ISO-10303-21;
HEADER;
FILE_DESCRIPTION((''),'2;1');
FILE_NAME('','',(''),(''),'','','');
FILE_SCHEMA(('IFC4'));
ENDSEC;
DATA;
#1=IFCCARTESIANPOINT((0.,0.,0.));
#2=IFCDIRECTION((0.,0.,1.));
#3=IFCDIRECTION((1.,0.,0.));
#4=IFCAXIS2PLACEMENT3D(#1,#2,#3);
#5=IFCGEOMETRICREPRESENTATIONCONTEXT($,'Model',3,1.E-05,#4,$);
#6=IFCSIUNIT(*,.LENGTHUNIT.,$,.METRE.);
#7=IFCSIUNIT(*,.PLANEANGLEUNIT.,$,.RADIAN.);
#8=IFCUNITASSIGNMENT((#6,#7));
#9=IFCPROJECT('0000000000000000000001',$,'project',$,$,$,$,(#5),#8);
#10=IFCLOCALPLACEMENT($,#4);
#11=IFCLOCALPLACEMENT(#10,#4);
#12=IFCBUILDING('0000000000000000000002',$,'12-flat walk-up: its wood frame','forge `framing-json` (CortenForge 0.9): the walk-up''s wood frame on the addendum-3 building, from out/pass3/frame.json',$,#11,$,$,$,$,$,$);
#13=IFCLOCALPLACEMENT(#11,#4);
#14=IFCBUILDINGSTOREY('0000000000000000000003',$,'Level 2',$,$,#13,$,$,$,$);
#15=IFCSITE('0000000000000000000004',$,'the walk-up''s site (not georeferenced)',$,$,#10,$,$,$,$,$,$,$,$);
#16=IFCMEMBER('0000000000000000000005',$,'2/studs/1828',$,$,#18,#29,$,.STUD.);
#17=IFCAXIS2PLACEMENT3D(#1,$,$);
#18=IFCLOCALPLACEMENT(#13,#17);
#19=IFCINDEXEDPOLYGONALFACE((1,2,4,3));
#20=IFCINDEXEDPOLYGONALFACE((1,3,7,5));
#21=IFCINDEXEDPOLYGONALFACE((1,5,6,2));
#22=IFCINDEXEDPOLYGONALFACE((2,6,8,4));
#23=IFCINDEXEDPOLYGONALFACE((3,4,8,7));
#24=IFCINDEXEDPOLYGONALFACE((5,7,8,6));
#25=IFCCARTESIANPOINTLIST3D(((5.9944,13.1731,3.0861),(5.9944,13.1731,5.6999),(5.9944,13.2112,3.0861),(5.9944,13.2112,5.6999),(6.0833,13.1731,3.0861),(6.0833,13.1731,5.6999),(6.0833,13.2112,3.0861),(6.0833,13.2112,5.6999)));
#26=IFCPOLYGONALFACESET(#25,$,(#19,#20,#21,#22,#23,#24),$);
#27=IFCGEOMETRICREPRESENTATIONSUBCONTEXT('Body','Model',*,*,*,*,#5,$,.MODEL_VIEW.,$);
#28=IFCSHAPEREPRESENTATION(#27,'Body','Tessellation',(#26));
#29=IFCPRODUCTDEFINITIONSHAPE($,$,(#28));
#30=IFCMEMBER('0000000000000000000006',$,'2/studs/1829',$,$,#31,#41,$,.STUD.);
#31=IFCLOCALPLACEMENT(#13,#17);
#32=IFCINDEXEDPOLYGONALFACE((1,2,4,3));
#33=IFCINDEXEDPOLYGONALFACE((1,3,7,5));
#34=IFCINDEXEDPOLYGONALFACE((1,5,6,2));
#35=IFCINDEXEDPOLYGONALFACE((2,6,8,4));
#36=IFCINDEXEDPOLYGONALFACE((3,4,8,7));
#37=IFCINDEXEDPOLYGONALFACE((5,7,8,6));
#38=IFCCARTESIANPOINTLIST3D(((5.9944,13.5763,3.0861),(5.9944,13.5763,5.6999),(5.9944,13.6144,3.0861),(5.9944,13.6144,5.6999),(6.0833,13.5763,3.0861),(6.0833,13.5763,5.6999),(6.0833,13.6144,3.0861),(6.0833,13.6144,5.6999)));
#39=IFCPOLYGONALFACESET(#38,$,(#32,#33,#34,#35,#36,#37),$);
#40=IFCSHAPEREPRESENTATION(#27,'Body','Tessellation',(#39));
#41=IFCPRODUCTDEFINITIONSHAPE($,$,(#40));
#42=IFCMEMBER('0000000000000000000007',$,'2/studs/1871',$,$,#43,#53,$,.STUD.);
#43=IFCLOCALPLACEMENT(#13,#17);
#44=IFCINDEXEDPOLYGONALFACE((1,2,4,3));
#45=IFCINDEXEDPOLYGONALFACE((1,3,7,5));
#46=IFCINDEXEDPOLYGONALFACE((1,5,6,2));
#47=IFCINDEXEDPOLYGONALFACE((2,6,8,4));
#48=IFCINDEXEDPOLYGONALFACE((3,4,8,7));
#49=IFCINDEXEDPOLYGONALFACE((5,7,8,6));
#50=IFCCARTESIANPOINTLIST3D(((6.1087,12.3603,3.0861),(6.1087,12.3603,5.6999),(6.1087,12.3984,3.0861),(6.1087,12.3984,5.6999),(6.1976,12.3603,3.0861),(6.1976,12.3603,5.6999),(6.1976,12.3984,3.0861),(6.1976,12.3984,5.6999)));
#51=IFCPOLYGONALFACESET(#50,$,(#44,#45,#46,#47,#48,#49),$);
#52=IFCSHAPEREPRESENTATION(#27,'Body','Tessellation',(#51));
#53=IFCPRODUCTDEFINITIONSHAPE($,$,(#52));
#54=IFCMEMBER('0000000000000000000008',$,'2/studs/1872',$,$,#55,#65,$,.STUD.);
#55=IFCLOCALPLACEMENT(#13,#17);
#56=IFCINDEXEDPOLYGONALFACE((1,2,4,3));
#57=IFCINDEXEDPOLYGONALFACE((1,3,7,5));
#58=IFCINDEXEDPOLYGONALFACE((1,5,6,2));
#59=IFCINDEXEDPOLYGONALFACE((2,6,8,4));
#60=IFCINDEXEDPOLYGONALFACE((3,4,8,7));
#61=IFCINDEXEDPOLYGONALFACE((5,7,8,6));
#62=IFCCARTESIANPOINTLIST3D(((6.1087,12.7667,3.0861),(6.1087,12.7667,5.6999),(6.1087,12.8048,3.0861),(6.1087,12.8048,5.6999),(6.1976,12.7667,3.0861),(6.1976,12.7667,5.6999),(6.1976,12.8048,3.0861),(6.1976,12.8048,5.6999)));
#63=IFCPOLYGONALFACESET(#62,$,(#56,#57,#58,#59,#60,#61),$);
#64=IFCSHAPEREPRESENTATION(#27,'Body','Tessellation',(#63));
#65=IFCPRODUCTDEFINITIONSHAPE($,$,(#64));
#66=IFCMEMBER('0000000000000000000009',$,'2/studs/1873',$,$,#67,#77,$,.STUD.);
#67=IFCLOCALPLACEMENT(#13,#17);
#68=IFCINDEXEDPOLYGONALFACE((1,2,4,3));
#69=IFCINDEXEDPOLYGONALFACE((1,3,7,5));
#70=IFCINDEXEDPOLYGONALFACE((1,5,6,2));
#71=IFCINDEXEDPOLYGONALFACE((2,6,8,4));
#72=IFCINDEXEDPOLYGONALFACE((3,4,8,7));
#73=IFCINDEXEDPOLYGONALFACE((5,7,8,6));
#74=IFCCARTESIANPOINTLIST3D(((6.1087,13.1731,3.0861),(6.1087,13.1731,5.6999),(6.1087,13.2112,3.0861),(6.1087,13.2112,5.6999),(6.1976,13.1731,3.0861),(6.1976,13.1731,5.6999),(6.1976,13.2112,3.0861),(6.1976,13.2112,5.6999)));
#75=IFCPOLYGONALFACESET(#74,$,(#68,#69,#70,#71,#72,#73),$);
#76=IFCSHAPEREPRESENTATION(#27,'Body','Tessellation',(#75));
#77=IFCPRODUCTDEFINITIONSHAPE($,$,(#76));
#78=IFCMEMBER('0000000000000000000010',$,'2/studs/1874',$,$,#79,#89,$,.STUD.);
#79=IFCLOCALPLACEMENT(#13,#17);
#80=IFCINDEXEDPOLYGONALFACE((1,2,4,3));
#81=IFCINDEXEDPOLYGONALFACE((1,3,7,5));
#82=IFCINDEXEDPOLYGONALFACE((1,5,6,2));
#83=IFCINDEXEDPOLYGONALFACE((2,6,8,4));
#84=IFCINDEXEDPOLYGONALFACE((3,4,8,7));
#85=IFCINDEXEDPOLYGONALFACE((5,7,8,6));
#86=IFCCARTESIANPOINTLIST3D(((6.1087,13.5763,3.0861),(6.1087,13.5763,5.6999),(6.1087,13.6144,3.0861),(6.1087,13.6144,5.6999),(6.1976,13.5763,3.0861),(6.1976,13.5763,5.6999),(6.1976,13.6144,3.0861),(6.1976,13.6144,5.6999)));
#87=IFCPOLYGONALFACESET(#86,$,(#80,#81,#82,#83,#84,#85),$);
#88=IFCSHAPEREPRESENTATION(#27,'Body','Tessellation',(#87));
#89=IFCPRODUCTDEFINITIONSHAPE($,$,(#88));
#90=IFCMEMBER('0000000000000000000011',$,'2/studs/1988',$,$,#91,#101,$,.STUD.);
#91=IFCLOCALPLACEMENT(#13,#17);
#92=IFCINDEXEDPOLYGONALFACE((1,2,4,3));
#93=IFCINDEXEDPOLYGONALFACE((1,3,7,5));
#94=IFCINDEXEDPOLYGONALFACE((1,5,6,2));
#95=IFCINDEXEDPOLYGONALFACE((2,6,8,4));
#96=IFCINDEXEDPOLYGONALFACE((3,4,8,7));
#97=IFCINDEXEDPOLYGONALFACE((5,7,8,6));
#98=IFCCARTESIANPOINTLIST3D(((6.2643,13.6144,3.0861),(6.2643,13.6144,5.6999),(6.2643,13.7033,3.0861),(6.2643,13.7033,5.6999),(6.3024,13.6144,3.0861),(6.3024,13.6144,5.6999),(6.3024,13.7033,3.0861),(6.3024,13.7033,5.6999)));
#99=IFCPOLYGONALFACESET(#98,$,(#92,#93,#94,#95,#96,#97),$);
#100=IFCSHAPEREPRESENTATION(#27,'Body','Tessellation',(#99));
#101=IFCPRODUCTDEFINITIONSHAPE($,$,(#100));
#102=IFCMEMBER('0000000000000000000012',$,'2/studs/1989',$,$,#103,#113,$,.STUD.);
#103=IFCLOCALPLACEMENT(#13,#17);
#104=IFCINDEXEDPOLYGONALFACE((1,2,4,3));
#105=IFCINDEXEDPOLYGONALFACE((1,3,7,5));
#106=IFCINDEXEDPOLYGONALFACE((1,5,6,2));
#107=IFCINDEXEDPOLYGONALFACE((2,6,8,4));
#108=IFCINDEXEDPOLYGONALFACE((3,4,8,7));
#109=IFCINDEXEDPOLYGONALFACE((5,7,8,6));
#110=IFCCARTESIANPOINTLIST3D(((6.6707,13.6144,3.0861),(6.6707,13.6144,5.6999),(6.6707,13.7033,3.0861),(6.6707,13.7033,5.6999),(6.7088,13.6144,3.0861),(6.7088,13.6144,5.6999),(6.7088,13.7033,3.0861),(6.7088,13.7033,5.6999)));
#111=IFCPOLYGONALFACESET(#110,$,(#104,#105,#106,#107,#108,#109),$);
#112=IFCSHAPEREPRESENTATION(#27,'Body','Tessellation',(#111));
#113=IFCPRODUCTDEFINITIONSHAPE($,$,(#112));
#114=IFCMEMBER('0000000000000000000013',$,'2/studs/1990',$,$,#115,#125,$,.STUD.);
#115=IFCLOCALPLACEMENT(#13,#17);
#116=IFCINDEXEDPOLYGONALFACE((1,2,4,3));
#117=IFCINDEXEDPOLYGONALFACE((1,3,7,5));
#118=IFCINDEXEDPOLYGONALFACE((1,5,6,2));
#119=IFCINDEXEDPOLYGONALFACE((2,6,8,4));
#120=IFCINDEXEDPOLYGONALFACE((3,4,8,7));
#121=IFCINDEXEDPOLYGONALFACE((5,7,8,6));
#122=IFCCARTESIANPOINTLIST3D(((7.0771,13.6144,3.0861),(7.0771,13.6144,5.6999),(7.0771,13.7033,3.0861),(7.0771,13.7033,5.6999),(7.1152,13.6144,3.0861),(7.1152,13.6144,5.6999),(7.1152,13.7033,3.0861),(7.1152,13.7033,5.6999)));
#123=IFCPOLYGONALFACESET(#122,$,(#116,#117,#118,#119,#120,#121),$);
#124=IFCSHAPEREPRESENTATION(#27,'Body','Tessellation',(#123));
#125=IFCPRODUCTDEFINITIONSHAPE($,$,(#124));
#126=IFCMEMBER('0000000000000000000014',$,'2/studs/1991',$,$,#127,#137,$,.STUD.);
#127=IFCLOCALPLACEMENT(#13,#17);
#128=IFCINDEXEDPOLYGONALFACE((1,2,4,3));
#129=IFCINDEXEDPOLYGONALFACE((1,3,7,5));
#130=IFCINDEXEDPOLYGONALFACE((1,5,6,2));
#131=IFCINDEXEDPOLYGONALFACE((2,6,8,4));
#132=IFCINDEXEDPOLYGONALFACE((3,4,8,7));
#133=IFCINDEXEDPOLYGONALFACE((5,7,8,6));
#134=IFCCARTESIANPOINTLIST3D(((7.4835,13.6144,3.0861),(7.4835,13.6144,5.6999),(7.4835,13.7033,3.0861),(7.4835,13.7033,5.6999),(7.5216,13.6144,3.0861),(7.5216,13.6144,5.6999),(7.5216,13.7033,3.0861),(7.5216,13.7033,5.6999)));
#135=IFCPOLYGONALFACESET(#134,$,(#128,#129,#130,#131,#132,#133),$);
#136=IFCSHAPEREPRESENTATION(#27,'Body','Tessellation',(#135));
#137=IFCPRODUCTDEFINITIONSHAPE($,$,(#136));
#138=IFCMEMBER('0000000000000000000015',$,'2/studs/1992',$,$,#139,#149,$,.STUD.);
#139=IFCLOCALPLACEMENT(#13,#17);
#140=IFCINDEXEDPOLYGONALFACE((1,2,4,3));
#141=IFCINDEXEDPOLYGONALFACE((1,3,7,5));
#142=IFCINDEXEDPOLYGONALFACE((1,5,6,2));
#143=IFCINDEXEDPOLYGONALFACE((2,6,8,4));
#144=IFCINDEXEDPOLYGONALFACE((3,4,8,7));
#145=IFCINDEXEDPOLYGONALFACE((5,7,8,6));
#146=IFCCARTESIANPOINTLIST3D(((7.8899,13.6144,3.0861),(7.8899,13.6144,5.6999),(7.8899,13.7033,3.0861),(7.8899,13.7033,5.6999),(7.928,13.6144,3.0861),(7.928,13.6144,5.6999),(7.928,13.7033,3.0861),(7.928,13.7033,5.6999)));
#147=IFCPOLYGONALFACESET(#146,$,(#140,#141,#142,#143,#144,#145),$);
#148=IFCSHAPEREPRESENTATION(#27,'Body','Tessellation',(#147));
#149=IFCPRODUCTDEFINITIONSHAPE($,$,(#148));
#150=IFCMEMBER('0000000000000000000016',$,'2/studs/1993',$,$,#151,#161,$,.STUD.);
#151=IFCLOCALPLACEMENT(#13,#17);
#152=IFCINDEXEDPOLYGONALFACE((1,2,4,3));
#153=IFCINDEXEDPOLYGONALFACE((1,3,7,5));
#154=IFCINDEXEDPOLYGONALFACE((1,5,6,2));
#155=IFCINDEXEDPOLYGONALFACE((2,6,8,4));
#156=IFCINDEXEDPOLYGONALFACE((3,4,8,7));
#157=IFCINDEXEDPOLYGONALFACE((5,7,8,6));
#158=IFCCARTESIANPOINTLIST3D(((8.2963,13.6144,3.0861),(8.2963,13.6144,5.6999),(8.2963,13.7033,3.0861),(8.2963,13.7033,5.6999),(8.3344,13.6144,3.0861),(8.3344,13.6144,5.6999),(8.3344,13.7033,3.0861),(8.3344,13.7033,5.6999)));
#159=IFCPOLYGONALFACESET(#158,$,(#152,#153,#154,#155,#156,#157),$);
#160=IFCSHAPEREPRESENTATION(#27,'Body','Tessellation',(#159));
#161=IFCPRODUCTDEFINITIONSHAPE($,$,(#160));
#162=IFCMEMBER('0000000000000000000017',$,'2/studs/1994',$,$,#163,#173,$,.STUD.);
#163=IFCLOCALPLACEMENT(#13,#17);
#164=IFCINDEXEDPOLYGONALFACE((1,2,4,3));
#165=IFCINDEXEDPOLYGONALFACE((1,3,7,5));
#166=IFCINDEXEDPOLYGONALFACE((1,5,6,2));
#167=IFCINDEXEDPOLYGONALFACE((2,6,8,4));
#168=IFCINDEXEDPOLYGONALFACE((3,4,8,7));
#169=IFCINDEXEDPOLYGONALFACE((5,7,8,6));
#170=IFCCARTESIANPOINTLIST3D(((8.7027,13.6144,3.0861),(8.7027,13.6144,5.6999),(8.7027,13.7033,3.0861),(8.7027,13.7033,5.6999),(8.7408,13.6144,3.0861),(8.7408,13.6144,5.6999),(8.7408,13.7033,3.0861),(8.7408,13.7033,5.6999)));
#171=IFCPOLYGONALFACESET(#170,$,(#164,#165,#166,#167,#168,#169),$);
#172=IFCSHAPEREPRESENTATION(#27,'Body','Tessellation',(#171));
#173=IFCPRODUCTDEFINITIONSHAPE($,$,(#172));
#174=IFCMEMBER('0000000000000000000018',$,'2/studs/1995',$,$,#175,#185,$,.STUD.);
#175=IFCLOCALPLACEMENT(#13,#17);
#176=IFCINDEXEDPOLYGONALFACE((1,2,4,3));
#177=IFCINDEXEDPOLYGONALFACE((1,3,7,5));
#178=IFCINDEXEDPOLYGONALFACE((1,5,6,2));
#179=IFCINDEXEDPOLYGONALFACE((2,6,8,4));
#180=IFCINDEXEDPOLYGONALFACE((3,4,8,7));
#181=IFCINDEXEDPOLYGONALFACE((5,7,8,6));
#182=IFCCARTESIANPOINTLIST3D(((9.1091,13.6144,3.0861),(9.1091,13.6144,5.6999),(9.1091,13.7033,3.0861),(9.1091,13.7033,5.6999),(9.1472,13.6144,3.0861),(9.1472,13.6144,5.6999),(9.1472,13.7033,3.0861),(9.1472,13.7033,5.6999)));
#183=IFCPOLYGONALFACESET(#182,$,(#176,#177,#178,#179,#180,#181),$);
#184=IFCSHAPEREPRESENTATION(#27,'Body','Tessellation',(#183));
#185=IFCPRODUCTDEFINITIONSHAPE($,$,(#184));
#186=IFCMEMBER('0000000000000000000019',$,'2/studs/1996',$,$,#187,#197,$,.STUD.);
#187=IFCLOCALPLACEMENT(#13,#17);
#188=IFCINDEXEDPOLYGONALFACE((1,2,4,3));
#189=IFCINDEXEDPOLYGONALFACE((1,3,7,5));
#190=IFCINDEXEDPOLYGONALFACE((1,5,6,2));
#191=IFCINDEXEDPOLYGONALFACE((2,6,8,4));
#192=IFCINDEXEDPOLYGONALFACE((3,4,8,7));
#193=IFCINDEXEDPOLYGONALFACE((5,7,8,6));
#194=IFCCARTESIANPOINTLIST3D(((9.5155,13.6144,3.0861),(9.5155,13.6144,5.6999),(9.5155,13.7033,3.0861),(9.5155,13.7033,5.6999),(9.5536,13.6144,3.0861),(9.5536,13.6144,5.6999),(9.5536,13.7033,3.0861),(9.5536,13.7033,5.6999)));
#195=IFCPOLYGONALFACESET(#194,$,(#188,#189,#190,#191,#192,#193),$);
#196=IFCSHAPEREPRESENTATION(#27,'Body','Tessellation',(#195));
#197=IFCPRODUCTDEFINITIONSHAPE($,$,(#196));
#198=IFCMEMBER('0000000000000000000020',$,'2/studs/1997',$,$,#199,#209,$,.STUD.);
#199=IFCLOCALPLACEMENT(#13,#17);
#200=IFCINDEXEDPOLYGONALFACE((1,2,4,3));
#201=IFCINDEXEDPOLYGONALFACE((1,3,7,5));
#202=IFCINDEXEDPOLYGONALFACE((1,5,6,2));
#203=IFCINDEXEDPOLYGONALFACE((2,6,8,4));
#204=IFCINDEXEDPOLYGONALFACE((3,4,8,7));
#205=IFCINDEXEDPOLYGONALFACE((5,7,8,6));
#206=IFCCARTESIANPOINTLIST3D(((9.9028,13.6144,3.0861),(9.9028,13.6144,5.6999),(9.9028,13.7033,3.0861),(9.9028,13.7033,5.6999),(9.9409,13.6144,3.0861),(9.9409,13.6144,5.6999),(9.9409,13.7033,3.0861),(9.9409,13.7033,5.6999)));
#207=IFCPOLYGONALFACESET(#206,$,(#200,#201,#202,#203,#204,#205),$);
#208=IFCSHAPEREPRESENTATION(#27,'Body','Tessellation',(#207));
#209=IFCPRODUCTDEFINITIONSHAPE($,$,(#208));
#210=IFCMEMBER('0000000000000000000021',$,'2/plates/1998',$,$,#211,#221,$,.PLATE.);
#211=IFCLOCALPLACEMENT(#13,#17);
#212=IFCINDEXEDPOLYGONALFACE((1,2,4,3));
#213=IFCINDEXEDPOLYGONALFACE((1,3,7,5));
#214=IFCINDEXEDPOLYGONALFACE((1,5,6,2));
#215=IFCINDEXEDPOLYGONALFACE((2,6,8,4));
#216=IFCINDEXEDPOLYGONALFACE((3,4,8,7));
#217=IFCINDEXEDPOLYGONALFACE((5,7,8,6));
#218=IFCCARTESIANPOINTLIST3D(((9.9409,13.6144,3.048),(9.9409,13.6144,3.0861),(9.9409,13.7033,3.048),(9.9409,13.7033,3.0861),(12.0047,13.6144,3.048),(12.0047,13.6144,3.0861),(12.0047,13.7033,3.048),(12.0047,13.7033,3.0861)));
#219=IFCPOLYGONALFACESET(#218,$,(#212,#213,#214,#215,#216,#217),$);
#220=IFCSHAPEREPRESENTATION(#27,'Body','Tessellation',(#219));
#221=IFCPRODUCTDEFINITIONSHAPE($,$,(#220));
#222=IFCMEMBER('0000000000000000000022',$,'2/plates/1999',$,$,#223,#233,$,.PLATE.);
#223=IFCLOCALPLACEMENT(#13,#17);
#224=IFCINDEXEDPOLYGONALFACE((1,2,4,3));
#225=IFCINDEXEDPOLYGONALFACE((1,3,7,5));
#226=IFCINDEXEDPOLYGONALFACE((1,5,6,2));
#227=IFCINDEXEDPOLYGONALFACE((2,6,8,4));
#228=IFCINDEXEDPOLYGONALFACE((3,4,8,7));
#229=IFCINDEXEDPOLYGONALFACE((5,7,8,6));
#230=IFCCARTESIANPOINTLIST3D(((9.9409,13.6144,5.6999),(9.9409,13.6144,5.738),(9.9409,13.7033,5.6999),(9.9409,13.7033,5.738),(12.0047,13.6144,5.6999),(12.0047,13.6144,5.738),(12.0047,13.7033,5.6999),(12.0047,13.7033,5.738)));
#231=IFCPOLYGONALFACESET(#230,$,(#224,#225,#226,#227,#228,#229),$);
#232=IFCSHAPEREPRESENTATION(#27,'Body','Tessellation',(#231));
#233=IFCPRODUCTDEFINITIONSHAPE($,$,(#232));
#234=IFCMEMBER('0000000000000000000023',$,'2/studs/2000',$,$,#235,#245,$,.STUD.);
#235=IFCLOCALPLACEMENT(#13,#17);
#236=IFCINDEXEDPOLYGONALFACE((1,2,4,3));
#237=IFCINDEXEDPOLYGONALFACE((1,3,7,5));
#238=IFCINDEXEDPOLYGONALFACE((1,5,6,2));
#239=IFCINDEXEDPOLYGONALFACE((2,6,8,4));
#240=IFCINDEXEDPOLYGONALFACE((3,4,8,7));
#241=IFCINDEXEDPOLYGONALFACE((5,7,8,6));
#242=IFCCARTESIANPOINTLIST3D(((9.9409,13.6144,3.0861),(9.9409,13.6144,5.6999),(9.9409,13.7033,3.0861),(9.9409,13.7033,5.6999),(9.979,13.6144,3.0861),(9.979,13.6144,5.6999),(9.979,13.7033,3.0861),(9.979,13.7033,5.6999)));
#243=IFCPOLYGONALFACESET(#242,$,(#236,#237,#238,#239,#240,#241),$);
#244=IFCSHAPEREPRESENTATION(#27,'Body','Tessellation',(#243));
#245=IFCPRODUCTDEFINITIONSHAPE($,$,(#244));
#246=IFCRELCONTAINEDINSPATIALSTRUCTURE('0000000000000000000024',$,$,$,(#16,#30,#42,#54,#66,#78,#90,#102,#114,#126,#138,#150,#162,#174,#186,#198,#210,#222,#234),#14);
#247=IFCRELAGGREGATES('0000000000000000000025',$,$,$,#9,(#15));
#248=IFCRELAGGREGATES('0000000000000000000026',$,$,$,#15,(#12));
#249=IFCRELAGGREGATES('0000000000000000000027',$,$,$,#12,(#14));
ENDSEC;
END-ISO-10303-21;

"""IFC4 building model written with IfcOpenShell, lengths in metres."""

from ifc_helpers import new_model, si_unit, frame, frame_2d, origin, origin_with_axes, place, context, subcontext, project, spatial, rectangle, extrude, element, save


model = new_model("IFC4")

# Units and contexts
model_context = context("Model", 3, precision=1e-05, world=origin_with_axes())
body_context = subcontext(model_context, "Body", "Model", "MODEL_VIEW")
ifc_project = project(units=[si_unit("LENGTHUNIT", "METRE"), si_unit("PLANEANGLEUNIT", "RADIAN")], contexts=[model_context])

# Site, building, storey
site_placement = place(None, origin_with_axes())
site = spatial("IfcSite", under=ifc_project, at=site_placement, Name="the walk-up's site (not georeferenced)")
building_placement = place(site_placement, origin_with_axes())
building = spatial("IfcBuilding", under=site, at=building_placement, Name="12-flat walk-up: its wood frame", Description="forge `framing-json` (CortenForge 0.9): the walk-up's wood frame on the addendum-3 building, from out/pass3/frame.json")
storey_placement = place(building_placement, origin_with_axes())
storey = spatial("IfcBuildingStorey", under=building, at=storey_placement, Name="Level 2")

# Members
for number, where, z_axis, x_axis, name in (
    (1, (5.9944, 13.1731, 3.0861), (0.0, 0.0, 1.0), (1.0, 0.0, 0.0), "2/studs/1828"),
    (2, (5.9944, 13.5763, 3.0861), (0.0, 0.0, 1.0), (1.0, 0.0, 0.0), "2/studs/1829"),
    (3, (6.1087, 12.3603, 3.0861), (0.0, 0.0, 1.0), (1.0, 0.0, 0.0), "2/studs/1871"),
    (4, (6.1087, 12.7667, 3.0861), (0.0, 0.0, 1.0), (1.0, 0.0, 0.0), "2/studs/1872"),
    (5, (6.1087, 13.1731, 3.0861), (0.0, 0.0, 1.0), (1.0, 0.0, 0.0), "2/studs/1873"),
    (6, (6.1087, 13.5763, 3.0861), (0.0, 0.0, 1.0), (1.0, 0.0, 0.0), "2/studs/1874"),
):
    element("IfcMember", number, at=place(storey_placement, frame(where, z_axis=z_axis, x_axis=x_axis)), inside=storey, Name=name, PredefinedType="STUD", context=body_context, shape_type="SweptSolid", body=[
        extrude(rectangle(XDim=0.0889, YDim=0.0381, at=frame_2d((0.0445, 0.0191))), origin(), (0.0, 0.0, 1.0), 2.6138),
    ])
for number, where, z_axis, x_axis, name in (
    (7, (6.2643, 13.6144, 3.0861), (0.0, 0.0, 1.0), (1.0, 0.0, 0.0), "2/studs/1988"),
    (8, (6.6707, 13.6144, 3.0861), (0.0, 0.0, 1.0), (1.0, 0.0, 0.0), "2/studs/1989"),
    (9, (7.0771, 13.6144, 3.0861), (0.0, 0.0, 1.0), (1.0, 0.0, 0.0), "2/studs/1990"),
    (10, (7.4835, 13.6144, 3.0861), (0.0, 0.0, 1.0), (1.0, 0.0, 0.0), "2/studs/1991"),
    (11, (7.8899, 13.6144, 3.0861), (0.0, 0.0, 1.0), (1.0, 0.0, 0.0), "2/studs/1992"),
    (12, (8.2963, 13.6144, 3.0861), (0.0, 0.0, 1.0), (1.0, 0.0, 0.0), "2/studs/1993"),
    (13, (8.7027, 13.6144, 3.0861), (0.0, 0.0, 1.0), (1.0, 0.0, 0.0), "2/studs/1994"),
    (14, (9.1091, 13.6144, 3.0861), (0.0, 0.0, 1.0), (1.0, 0.0, 0.0), "2/studs/1995"),
    (15, (9.5155, 13.6144, 3.0861), (0.0, 0.0, 1.0), (1.0, 0.0, 0.0), "2/studs/1996"),
    (16, (9.9028, 13.6144, 3.0861), (0.0, 0.0, 1.0), (1.0, 0.0, 0.0), "2/studs/1997"),
):
    element("IfcMember", number, at=place(storey_placement, frame(where, z_axis=z_axis, x_axis=x_axis)), inside=storey, Name=name, PredefinedType="STUD", context=body_context, shape_type="SweptSolid", body=[
        extrude(rectangle(XDim=0.0381, YDim=0.0889, at=frame_2d((0.0191, 0.0445))), origin(), (0.0, 0.0, 1.0), 2.6138),
    ])
for number, where, z_axis, x_axis, name in (
    (17, (9.9409, 13.6144, 3.048), (0.0, 0.0, 1.0), (1.0, 0.0, 0.0), "2/plates/1998"),
    (18, (9.9409, 13.6144, 5.6999), (0.0, 0.0, 1.0), (1.0, 0.0, 0.0), "2/plates/1999"),
):
    element("IfcMember", number, at=place(storey_placement, frame(where, z_axis=z_axis, x_axis=x_axis)), inside=storey, Name=name, PredefinedType="PLATE", context=body_context, shape_type="SweptSolid", body=[
        extrude(rectangle(XDim=2.0638, YDim=0.0889, at=frame_2d((1.0319, 0.0445))), origin(), (0.0, 0.0, 1.0), 0.0381),
    ])
member_1_placement = place(storey_placement, frame((9.9409, 13.6144, 3.0861), z_axis=(0.0, 0.0, 1.0), x_axis=(1.0, 0.0, 0.0)))
element("IfcMember", 19, at=member_1_placement, inside=storey, Name="2/studs/2000", PredefinedType="STUD", context=body_context, shape_type="SweptSolid", body=[
    extrude(rectangle(XDim=0.0381, YDim=0.0889, at=frame_2d((0.0191, 0.0445))), origin(), (0.0, 0.0, 1.0), 2.6138),
])

save(model, "model.ifc")
